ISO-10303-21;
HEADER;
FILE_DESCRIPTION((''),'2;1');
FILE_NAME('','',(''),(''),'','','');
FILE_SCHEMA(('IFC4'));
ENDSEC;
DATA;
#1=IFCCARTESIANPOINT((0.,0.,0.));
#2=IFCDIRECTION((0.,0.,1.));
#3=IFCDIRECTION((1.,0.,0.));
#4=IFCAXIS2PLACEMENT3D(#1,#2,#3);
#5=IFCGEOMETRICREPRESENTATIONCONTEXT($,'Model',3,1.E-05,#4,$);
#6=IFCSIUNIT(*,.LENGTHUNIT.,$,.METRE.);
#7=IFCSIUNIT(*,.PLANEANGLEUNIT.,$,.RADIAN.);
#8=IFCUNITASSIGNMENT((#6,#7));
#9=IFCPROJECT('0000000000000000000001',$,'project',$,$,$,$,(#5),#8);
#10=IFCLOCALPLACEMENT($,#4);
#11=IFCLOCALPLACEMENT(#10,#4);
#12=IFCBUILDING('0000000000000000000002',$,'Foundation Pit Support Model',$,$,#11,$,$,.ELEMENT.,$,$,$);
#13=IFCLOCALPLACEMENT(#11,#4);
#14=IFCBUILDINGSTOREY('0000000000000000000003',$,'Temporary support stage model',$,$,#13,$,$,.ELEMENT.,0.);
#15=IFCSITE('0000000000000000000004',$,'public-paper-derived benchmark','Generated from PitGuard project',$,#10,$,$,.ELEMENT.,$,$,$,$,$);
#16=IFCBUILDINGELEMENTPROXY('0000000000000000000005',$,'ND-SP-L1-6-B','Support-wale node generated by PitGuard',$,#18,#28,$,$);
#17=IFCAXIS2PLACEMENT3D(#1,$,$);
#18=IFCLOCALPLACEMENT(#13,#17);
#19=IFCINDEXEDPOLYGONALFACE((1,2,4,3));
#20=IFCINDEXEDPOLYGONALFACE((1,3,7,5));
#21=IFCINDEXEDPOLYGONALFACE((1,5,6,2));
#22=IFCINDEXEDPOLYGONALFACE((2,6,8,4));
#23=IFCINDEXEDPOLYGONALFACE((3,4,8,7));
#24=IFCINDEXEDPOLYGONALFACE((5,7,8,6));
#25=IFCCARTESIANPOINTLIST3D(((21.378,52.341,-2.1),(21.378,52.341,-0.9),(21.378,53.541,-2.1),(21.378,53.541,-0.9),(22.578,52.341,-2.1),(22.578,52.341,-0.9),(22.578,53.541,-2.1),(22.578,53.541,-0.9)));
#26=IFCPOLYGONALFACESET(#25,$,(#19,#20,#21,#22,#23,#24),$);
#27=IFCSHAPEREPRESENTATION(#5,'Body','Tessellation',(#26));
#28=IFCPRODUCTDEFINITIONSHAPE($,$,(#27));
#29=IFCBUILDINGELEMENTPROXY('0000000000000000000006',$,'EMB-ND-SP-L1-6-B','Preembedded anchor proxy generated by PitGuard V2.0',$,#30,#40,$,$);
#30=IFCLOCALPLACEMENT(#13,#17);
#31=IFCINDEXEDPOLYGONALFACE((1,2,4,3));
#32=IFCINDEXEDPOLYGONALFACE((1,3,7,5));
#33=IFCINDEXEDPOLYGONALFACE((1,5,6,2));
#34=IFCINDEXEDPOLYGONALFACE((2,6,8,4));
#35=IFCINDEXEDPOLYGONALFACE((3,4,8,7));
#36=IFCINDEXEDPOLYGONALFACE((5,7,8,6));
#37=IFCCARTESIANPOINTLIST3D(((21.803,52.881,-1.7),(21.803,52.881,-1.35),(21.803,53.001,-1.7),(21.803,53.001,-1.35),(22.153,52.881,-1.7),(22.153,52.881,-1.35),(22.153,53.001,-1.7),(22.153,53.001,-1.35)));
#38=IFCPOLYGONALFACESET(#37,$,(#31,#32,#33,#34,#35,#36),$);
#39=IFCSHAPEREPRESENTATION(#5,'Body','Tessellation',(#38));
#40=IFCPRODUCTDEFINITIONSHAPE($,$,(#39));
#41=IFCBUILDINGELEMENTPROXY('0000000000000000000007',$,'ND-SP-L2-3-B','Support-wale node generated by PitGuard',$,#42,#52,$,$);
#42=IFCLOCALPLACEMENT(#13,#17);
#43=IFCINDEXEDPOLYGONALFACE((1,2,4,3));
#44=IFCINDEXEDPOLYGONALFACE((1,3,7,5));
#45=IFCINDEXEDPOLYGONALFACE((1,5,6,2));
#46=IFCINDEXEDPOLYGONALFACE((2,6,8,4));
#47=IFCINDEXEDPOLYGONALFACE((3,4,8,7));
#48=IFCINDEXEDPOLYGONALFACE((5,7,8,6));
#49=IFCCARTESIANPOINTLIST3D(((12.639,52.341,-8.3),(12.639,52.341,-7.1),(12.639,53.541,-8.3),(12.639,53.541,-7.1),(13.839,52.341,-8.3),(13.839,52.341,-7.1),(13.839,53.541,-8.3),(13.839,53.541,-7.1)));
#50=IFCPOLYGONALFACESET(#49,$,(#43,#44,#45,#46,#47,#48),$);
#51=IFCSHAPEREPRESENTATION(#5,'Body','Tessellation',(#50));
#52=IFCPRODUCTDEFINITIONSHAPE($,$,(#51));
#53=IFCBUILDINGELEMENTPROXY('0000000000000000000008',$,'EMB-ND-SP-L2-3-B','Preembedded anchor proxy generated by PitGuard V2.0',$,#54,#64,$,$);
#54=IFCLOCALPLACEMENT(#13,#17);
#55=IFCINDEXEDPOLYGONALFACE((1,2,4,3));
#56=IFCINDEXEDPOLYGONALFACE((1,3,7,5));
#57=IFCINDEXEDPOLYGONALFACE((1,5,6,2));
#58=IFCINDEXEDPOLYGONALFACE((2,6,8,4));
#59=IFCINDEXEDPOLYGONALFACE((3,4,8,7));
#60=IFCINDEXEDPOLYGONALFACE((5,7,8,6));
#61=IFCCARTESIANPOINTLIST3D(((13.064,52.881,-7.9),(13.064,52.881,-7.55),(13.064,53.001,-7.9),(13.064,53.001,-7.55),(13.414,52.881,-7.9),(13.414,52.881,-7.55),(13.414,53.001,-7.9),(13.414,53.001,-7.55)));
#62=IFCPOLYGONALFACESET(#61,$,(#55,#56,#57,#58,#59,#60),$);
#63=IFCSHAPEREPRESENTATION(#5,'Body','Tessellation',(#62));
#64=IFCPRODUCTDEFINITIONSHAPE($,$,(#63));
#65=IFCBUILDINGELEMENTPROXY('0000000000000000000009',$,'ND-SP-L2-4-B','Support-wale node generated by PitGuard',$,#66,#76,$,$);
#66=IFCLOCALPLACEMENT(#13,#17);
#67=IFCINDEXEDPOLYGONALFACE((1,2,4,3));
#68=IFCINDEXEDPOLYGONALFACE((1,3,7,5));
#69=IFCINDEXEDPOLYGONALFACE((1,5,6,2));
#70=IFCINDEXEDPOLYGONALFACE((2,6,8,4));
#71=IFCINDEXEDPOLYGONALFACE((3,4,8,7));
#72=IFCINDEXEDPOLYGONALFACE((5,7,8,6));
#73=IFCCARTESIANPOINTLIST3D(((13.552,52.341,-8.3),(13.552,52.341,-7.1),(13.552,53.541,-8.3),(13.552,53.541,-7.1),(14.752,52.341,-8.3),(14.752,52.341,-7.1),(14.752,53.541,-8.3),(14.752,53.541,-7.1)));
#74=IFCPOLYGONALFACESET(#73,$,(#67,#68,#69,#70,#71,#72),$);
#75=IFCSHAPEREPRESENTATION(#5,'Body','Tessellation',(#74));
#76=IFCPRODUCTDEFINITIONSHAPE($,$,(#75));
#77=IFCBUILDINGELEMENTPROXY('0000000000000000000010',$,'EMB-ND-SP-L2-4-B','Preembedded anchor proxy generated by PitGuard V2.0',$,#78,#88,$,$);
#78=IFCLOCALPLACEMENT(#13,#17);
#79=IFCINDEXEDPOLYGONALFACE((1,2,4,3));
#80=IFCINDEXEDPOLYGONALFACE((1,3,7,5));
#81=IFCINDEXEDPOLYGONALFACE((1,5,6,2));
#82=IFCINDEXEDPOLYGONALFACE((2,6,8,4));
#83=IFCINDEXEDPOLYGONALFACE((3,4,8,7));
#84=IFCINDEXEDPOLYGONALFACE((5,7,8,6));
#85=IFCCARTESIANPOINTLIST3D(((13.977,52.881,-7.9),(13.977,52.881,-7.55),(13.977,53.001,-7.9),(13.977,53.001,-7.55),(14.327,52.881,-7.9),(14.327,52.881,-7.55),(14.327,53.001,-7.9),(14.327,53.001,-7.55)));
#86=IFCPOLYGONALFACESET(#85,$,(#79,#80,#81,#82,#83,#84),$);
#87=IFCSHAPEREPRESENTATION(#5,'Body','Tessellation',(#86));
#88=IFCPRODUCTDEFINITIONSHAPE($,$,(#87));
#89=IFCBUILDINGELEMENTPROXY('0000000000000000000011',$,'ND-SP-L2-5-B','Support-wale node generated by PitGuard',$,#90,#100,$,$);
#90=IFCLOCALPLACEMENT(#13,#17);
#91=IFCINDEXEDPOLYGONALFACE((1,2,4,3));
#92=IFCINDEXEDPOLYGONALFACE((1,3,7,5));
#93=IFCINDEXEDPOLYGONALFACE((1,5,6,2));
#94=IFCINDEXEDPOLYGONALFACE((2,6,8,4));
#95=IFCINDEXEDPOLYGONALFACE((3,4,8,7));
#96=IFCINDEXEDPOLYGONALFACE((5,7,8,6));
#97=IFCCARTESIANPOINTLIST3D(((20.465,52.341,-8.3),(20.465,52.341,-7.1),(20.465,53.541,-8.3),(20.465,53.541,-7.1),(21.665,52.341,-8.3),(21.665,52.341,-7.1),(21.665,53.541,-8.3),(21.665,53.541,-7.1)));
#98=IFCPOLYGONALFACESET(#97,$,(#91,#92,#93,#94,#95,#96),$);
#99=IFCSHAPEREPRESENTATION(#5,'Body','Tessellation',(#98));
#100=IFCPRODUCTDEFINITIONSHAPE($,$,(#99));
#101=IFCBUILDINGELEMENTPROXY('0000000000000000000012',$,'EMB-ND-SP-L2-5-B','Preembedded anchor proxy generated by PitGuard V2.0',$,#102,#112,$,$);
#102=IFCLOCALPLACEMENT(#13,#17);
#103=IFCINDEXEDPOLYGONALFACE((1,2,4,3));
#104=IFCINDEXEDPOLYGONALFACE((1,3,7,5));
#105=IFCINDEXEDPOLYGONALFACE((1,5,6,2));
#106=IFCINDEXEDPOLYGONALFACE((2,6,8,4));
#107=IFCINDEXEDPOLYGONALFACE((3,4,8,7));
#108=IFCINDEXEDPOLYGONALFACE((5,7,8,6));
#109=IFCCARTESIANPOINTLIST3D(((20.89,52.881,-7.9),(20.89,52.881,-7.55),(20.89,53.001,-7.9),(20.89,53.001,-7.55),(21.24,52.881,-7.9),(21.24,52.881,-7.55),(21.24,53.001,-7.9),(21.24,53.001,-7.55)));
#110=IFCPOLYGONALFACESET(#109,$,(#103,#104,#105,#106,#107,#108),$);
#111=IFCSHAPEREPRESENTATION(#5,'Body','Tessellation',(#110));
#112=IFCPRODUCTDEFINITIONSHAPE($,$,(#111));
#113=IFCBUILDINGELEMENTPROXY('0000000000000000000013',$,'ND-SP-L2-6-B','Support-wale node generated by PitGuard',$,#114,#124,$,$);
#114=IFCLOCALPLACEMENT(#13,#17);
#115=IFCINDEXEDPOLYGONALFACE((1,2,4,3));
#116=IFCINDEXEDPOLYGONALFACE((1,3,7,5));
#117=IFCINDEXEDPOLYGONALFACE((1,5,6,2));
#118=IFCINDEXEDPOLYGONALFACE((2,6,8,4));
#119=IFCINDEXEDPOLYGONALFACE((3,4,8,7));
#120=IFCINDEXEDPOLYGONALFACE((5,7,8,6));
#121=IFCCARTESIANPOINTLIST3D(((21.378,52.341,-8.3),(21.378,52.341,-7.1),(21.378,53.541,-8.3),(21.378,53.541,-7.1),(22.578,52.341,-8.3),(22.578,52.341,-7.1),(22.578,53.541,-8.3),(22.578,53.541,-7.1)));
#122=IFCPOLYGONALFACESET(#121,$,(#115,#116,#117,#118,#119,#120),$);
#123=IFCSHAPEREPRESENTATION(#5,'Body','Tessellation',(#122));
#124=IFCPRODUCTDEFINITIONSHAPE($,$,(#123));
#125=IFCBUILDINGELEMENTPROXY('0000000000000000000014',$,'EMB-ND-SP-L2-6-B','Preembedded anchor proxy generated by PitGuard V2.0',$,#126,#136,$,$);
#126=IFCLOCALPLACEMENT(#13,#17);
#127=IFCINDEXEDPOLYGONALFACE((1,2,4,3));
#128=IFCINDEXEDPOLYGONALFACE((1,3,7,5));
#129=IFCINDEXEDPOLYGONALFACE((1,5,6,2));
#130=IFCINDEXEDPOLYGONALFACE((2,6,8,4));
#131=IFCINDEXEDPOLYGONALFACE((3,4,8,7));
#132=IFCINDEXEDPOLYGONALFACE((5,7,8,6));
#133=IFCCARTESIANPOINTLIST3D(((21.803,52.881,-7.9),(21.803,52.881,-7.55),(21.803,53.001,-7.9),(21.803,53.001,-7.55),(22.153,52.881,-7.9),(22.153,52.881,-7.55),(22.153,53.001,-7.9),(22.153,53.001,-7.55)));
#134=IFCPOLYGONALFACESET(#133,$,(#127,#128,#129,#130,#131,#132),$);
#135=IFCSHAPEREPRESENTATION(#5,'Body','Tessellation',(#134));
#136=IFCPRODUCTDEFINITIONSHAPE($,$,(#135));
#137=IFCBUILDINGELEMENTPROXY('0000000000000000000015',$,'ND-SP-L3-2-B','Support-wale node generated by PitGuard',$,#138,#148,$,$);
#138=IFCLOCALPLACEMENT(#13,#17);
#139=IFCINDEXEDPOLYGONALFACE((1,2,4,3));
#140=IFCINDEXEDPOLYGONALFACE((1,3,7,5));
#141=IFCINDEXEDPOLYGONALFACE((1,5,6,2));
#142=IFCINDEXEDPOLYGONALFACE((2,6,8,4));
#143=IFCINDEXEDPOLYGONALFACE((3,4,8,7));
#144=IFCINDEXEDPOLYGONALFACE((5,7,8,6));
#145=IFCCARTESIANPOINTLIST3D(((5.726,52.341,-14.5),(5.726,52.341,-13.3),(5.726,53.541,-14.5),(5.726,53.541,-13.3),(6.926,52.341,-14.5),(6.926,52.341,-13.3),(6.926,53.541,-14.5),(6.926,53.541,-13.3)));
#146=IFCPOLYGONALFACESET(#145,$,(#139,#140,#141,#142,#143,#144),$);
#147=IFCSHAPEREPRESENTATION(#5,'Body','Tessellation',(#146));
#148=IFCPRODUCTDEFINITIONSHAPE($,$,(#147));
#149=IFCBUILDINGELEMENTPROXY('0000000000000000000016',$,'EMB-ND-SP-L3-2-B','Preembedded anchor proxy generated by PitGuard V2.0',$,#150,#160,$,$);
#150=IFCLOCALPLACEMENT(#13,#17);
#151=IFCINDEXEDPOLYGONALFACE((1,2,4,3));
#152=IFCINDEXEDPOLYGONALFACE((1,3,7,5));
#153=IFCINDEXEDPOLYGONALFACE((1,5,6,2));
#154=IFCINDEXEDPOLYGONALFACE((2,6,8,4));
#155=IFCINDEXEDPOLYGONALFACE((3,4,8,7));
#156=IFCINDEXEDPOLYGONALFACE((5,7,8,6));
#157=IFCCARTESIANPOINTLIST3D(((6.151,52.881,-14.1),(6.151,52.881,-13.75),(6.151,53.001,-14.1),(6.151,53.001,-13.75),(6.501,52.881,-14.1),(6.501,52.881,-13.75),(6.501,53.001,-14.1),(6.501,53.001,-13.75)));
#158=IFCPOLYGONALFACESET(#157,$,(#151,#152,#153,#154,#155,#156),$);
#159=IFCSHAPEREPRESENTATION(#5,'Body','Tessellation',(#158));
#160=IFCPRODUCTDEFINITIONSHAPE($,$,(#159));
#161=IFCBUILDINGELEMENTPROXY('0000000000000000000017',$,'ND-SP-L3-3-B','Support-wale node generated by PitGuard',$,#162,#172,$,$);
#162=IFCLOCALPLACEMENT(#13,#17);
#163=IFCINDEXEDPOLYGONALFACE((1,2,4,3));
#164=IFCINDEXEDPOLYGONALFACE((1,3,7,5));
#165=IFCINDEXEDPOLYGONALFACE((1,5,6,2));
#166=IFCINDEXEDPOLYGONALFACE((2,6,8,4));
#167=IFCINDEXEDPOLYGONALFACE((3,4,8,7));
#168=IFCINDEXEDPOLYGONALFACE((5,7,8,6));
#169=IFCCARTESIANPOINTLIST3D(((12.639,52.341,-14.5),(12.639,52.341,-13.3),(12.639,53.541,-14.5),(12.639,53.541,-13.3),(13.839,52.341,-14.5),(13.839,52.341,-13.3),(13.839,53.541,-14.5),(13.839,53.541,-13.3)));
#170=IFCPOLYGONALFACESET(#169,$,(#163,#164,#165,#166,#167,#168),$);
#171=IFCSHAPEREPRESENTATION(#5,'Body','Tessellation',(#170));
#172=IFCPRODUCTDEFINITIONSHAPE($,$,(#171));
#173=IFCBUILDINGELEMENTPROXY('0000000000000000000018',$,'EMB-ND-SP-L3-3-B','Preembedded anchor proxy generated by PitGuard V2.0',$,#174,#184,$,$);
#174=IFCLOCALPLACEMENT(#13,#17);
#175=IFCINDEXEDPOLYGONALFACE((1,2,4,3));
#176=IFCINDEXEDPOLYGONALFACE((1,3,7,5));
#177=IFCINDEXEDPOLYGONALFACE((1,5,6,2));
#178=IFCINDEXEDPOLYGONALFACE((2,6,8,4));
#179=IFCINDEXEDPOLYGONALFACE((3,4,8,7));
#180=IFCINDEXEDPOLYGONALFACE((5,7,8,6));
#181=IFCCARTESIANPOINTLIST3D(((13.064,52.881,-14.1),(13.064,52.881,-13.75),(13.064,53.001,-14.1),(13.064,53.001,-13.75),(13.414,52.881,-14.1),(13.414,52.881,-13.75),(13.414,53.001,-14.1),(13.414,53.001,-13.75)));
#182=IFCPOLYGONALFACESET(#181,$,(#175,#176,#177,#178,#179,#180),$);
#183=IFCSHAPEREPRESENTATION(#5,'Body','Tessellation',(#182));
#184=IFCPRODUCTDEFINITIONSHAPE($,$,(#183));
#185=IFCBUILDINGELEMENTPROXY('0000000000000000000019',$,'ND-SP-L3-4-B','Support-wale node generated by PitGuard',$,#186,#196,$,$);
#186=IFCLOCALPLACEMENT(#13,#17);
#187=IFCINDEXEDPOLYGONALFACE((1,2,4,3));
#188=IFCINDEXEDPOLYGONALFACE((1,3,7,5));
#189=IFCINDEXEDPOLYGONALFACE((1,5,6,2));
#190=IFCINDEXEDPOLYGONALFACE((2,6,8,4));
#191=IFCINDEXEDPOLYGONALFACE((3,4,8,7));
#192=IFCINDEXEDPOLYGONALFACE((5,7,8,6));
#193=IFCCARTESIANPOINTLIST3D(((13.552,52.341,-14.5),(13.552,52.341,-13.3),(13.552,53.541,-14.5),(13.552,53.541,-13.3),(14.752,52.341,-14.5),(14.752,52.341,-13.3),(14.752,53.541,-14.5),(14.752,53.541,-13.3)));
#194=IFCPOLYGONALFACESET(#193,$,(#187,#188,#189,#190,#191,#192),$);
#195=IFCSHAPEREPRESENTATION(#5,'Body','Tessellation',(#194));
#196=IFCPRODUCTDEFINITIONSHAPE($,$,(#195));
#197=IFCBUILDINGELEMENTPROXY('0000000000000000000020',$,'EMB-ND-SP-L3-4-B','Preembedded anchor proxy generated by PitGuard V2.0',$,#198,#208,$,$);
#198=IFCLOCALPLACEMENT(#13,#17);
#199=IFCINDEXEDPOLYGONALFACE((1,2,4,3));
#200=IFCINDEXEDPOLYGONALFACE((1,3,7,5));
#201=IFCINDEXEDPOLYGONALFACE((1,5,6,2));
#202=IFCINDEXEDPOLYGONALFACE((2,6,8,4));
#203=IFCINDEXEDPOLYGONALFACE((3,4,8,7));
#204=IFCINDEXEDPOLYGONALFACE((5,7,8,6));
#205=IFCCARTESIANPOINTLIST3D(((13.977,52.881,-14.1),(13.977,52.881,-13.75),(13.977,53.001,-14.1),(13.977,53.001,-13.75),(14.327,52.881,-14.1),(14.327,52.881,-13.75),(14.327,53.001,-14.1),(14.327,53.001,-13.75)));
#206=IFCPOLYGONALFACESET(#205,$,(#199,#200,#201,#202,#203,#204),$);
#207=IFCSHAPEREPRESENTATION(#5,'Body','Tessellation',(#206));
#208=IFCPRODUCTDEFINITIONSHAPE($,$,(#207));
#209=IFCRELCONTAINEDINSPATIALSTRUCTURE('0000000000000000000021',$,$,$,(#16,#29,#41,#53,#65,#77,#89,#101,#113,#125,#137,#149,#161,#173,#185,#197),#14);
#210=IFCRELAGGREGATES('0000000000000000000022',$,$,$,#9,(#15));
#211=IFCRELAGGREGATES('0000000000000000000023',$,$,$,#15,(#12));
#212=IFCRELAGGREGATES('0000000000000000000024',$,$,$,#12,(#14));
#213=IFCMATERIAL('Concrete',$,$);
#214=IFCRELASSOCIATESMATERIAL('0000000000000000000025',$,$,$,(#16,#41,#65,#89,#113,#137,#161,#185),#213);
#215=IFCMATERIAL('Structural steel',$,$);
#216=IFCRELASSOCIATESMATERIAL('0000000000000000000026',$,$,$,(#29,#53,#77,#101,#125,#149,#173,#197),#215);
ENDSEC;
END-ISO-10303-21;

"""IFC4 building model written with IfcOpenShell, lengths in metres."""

from ifc_helpers import new_model, si_unit, frame, origin_with_axes, origin_2d, place, context, project, spatial, rectangle, extrude, material, element, save


model = new_model("IFC4")

# Units and contexts
model_context = context("Model", 3, precision=1e-05, world=origin_with_axes())
ifc_project = project(units=[si_unit("LENGTHUNIT", "METRE"), si_unit("PLANEANGLEUNIT", "RADIAN")], contexts=[model_context])

# Site, building, storey
site_placement = place(None, origin_with_axes())
site = spatial("IfcSite", under=ifc_project, at=site_placement, Name="public-paper-derived benchmark", Description="Generated from PitGuard project", CompositionType="ELEMENT")
building_placement = place(site_placement, origin_with_axes())
building = spatial("IfcBuilding", under=site, at=building_placement, Name="Foundation Pit Support Model", CompositionType="ELEMENT")
storey_placement = place(building_placement, origin_with_axes())
storey = spatial("IfcBuildingStorey", under=building, at=storey_placement, Name="Temporary support stage model", CompositionType="ELEMENT", Elevation=0.0)

# Shared definitions
ifc_material_1 = material(Name="Structural steel")

# Building element proxies
ifc_material_2 = material(Name="Concrete")
proxy_1_placement = place(storey_placement, frame((21.978, 52.941, -2.1), z_axis=(0.0, 0.0, 1.0), x_axis=(1.0, 0.0, 0.0)))
element("IfcBuildingElementProxy", 1, at=proxy_1_placement, inside=storey, material=ifc_material_2, Name="ND-SP-L1-6-B", Description="Support-wale node generated by PitGuard", context=model_context, shape_type="SweptSolid", body=[
    extrude(rectangle(XDim=1.2, YDim=1.2, at=origin_2d()), origin_with_axes(), (0.0, 0.0, 1.0), 1.2),
])
proxy_2_placement = place(storey_placement, frame((21.978, 52.941, -1.7), z_axis=(0.0, 0.0, 1.0), x_axis=(1.0, 0.0, 0.0)))
element("IfcBuildingElementProxy", 2, at=proxy_2_placement, inside=storey, material=ifc_material_1, Name="EMB-ND-SP-L1-6-B", Description="Preembedded anchor proxy generated by PitGuard V2.0", context=model_context, shape_type="SweptSolid", body=[
    extrude(rectangle(XDim=0.35, YDim=0.12, at=origin_2d()), origin_with_axes(), (0.0, 0.0, 1.0), 0.35),
])
proxy_3_placement = place(storey_placement, frame((13.239, 52.941, -8.3), z_axis=(0.0, 0.0, 1.0), x_axis=(1.0, 0.0, 0.0)))
element("IfcBuildingElementProxy", 3, at=proxy_3_placement, inside=storey, material=ifc_material_2, Name="ND-SP-L2-3-B", Description="Support-wale node generated by PitGuard", context=model_context, shape_type="SweptSolid", body=[
    extrude(rectangle(XDim=1.2, YDim=1.2, at=origin_2d()), origin_with_axes(), (0.0, 0.0, 1.0), 1.2),
])
proxy_4_placement = place(storey_placement, frame((13.239, 52.941, -7.9), z_axis=(0.0, 0.0, 1.0), x_axis=(1.0, 0.0, 0.0)))
element("IfcBuildingElementProxy", 4, at=proxy_4_placement, inside=storey, material=ifc_material_1, Name="EMB-ND-SP-L2-3-B", Description="Preembedded anchor proxy generated by PitGuard V2.0", context=model_context, shape_type="SweptSolid", body=[
    extrude(rectangle(XDim=0.35, YDim=0.12, at=origin_2d()), origin_with_axes(), (0.0, 0.0, 1.0), 0.35),
])
proxy_5_placement = place(storey_placement, frame((14.152, 52.941, -8.3), z_axis=(0.0, 0.0, 1.0), x_axis=(1.0, 0.0, 0.0)))
element("IfcBuildingElementProxy", 5, at=proxy_5_placement, inside=storey, material=ifc_material_2, Name="ND-SP-L2-4-B", Description="Support-wale node generated by PitGuard", context=model_context, shape_type="SweptSolid", body=[
    extrude(rectangle(XDim=1.2, YDim=1.2, at=origin_2d()), origin_with_axes(), (0.0, 0.0, 1.0), 1.2),
])
proxy_6_placement = place(storey_placement, frame((14.152, 52.941, -7.9), z_axis=(0.0, 0.0, 1.0), x_axis=(1.0, 0.0, 0.0)))
element("IfcBuildingElementProxy", 6, at=proxy_6_placement, inside=storey, material=ifc_material_1, Name="EMB-ND-SP-L2-4-B", Description="Preembedded anchor proxy generated by PitGuard V2.0", context=model_context, shape_type="SweptSolid", body=[
    extrude(rectangle(XDim=0.35, YDim=0.12, at=origin_2d()), origin_with_axes(), (0.0, 0.0, 1.0), 0.35),
])
proxy_7_placement = place(storey_placement, frame((21.065, 52.941, -8.3), z_axis=(0.0, 0.0, 1.0), x_axis=(1.0, 0.0, 0.0)))
element("IfcBuildingElementProxy", 7, at=proxy_7_placement, inside=storey, material=ifc_material_2, Name="ND-SP-L2-5-B", Description="Support-wale node generated by PitGuard", context=model_context, shape_type="SweptSolid", body=[
    extrude(rectangle(XDim=1.2, YDim=1.2, at=origin_2d()), origin_with_axes(), (0.0, 0.0, 1.0), 1.2),
])
proxy_8_placement = place(storey_placement, frame((21.065, 52.941, -7.9), z_axis=(0.0, 0.0, 1.0), x_axis=(1.0, 0.0, 0.0)))
element("IfcBuildingElementProxy", 8, at=proxy_8_placement, inside=storey, material=ifc_material_1, Name="EMB-ND-SP-L2-5-B", Description="Preembedded anchor proxy generated by PitGuard V2.0", context=model_context, shape_type="SweptSolid", body=[
    extrude(rectangle(XDim=0.35, YDim=0.12, at=origin_2d()), origin_with_axes(), (0.0, 0.0, 1.0), 0.35),
])
proxy_9_placement = place(storey_placement, frame((21.978, 52.941, -8.3), z_axis=(0.0, 0.0, 1.0), x_axis=(1.0, 0.0, 0.0)))
element("IfcBuildingElementProxy", 9, at=proxy_9_placement, inside=storey, material=ifc_material_2, Name="ND-SP-L2-6-B", Description="Support-wale node generated by PitGuard", context=model_context, shape_type="SweptSolid", body=[
    extrude(rectangle(XDim=1.2, YDim=1.2, at=origin_2d()), origin_with_axes(), (0.0, 0.0, 1.0), 1.2),
])
proxy_10_placement = place(storey_placement, frame((21.978, 52.941, -7.9), z_axis=(0.0, 0.0, 1.0), x_axis=(1.0, 0.0, 0.0)))
element("IfcBuildingElementProxy", 10, at=proxy_10_placement, inside=storey, material=ifc_material_1, Name="EMB-ND-SP-L2-6-B", Description="Preembedded anchor proxy generated by PitGuard V2.0", context=model_context, shape_type="SweptSolid", body=[
    extrude(rectangle(XDim=0.35, YDim=0.12, at=origin_2d()), origin_with_axes(), (0.0, 0.0, 1.0), 0.35),
])
proxy_11_placement = place(storey_placement, frame((6.326, 52.941, -14.5), z_axis=(0.0, 0.0, 1.0), x_axis=(1.0, 0.0, 0.0)))
element("IfcBuildingElementProxy", 11, at=proxy_11_placement, inside=storey, material=ifc_material_2, Name="ND-SP-L3-2-B", Description="Support-wale node generated by PitGuard", context=model_context, shape_type="SweptSolid", body=[
    extrude(rectangle(XDim=1.2, YDim=1.2, at=origin_2d()), origin_with_axes(), (0.0, 0.0, 1.0), 1.2),
])
proxy_12_placement = place(storey_placement, frame((6.326, 52.941, -14.1), z_axis=(0.0, 0.0, 1.0), x_axis=(1.0, 0.0, 0.0)))
element("IfcBuildingElementProxy", 12, at=proxy_12_placement, inside=storey, material=ifc_material_1, Name="EMB-ND-SP-L3-2-B", Description="Preembedded anchor proxy generated by PitGuard V2.0", context=model_context, shape_type="SweptSolid", body=[
    extrude(rectangle(XDim=0.35, YDim=0.12, at=origin_2d()), origin_with_axes(), (0.0, 0.0, 1.0), 0.35),
])
proxy_13_placement = place(storey_placement, frame((13.239, 52.941, -14.5), z_axis=(0.0, 0.0, 1.0), x_axis=(1.0, 0.0, 0.0)))
element("IfcBuildingElementProxy", 13, at=proxy_13_placement, inside=storey, material=ifc_material_2, Name="ND-SP-L3-3-B", Description="Support-wale node generated by PitGuard", context=model_context, shape_type="SweptSolid", body=[
    extrude(rectangle(XDim=1.2, YDim=1.2, at=origin_2d()), origin_with_axes(), (0.0, 0.0, 1.0), 1.2),
])
proxy_14_placement = place(storey_placement, frame((13.239, 52.941, -14.1), z_axis=(0.0, 0.0, 1.0), x_axis=(1.0, 0.0, 0.0)))
element("IfcBuildingElementProxy", 14, at=proxy_14_placement, inside=storey, material=ifc_material_1, Name="EMB-ND-SP-L3-3-B", Description="Preembedded anchor proxy generated by PitGuard V2.0", context=model_context, shape_type="SweptSolid", body=[
    extrude(rectangle(XDim=0.35, YDim=0.12, at=origin_2d()), origin_with_axes(), (0.0, 0.0, 1.0), 0.35),
])
proxy_15_placement = place(storey_placement, frame((14.152, 52.941, -14.5), z_axis=(0.0, 0.0, 1.0), x_axis=(1.0, 0.0, 0.0)))
element("IfcBuildingElementProxy", 15, at=proxy_15_placement, inside=storey, material=ifc_material_2, Name="ND-SP-L3-4-B", Description="Support-wale node generated by PitGuard", context=model_context, shape_type="SweptSolid", body=[
    extrude(rectangle(XDim=1.2, YDim=1.2, at=origin_2d()), origin_with_axes(), (0.0, 0.0, 1.0), 1.2),
])
proxy_16_placement = place(storey_placement, frame((14.152, 52.941, -14.1), z_axis=(0.0, 0.0, 1.0), x_axis=(1.0, 0.0, 0.0)))
element("IfcBuildingElementProxy", 16, at=proxy_16_placement, inside=storey, material=ifc_material_1, Name="EMB-ND-SP-L3-4-B", Description="Preembedded anchor proxy generated by PitGuard V2.0", context=model_context, shape_type="SweptSolid", body=[
    extrude(rectangle(XDim=0.35, YDim=0.12, at=origin_2d()), origin_with_axes(), (0.0, 0.0, 1.0), 0.35),
])

save(model, "model.ifc")
